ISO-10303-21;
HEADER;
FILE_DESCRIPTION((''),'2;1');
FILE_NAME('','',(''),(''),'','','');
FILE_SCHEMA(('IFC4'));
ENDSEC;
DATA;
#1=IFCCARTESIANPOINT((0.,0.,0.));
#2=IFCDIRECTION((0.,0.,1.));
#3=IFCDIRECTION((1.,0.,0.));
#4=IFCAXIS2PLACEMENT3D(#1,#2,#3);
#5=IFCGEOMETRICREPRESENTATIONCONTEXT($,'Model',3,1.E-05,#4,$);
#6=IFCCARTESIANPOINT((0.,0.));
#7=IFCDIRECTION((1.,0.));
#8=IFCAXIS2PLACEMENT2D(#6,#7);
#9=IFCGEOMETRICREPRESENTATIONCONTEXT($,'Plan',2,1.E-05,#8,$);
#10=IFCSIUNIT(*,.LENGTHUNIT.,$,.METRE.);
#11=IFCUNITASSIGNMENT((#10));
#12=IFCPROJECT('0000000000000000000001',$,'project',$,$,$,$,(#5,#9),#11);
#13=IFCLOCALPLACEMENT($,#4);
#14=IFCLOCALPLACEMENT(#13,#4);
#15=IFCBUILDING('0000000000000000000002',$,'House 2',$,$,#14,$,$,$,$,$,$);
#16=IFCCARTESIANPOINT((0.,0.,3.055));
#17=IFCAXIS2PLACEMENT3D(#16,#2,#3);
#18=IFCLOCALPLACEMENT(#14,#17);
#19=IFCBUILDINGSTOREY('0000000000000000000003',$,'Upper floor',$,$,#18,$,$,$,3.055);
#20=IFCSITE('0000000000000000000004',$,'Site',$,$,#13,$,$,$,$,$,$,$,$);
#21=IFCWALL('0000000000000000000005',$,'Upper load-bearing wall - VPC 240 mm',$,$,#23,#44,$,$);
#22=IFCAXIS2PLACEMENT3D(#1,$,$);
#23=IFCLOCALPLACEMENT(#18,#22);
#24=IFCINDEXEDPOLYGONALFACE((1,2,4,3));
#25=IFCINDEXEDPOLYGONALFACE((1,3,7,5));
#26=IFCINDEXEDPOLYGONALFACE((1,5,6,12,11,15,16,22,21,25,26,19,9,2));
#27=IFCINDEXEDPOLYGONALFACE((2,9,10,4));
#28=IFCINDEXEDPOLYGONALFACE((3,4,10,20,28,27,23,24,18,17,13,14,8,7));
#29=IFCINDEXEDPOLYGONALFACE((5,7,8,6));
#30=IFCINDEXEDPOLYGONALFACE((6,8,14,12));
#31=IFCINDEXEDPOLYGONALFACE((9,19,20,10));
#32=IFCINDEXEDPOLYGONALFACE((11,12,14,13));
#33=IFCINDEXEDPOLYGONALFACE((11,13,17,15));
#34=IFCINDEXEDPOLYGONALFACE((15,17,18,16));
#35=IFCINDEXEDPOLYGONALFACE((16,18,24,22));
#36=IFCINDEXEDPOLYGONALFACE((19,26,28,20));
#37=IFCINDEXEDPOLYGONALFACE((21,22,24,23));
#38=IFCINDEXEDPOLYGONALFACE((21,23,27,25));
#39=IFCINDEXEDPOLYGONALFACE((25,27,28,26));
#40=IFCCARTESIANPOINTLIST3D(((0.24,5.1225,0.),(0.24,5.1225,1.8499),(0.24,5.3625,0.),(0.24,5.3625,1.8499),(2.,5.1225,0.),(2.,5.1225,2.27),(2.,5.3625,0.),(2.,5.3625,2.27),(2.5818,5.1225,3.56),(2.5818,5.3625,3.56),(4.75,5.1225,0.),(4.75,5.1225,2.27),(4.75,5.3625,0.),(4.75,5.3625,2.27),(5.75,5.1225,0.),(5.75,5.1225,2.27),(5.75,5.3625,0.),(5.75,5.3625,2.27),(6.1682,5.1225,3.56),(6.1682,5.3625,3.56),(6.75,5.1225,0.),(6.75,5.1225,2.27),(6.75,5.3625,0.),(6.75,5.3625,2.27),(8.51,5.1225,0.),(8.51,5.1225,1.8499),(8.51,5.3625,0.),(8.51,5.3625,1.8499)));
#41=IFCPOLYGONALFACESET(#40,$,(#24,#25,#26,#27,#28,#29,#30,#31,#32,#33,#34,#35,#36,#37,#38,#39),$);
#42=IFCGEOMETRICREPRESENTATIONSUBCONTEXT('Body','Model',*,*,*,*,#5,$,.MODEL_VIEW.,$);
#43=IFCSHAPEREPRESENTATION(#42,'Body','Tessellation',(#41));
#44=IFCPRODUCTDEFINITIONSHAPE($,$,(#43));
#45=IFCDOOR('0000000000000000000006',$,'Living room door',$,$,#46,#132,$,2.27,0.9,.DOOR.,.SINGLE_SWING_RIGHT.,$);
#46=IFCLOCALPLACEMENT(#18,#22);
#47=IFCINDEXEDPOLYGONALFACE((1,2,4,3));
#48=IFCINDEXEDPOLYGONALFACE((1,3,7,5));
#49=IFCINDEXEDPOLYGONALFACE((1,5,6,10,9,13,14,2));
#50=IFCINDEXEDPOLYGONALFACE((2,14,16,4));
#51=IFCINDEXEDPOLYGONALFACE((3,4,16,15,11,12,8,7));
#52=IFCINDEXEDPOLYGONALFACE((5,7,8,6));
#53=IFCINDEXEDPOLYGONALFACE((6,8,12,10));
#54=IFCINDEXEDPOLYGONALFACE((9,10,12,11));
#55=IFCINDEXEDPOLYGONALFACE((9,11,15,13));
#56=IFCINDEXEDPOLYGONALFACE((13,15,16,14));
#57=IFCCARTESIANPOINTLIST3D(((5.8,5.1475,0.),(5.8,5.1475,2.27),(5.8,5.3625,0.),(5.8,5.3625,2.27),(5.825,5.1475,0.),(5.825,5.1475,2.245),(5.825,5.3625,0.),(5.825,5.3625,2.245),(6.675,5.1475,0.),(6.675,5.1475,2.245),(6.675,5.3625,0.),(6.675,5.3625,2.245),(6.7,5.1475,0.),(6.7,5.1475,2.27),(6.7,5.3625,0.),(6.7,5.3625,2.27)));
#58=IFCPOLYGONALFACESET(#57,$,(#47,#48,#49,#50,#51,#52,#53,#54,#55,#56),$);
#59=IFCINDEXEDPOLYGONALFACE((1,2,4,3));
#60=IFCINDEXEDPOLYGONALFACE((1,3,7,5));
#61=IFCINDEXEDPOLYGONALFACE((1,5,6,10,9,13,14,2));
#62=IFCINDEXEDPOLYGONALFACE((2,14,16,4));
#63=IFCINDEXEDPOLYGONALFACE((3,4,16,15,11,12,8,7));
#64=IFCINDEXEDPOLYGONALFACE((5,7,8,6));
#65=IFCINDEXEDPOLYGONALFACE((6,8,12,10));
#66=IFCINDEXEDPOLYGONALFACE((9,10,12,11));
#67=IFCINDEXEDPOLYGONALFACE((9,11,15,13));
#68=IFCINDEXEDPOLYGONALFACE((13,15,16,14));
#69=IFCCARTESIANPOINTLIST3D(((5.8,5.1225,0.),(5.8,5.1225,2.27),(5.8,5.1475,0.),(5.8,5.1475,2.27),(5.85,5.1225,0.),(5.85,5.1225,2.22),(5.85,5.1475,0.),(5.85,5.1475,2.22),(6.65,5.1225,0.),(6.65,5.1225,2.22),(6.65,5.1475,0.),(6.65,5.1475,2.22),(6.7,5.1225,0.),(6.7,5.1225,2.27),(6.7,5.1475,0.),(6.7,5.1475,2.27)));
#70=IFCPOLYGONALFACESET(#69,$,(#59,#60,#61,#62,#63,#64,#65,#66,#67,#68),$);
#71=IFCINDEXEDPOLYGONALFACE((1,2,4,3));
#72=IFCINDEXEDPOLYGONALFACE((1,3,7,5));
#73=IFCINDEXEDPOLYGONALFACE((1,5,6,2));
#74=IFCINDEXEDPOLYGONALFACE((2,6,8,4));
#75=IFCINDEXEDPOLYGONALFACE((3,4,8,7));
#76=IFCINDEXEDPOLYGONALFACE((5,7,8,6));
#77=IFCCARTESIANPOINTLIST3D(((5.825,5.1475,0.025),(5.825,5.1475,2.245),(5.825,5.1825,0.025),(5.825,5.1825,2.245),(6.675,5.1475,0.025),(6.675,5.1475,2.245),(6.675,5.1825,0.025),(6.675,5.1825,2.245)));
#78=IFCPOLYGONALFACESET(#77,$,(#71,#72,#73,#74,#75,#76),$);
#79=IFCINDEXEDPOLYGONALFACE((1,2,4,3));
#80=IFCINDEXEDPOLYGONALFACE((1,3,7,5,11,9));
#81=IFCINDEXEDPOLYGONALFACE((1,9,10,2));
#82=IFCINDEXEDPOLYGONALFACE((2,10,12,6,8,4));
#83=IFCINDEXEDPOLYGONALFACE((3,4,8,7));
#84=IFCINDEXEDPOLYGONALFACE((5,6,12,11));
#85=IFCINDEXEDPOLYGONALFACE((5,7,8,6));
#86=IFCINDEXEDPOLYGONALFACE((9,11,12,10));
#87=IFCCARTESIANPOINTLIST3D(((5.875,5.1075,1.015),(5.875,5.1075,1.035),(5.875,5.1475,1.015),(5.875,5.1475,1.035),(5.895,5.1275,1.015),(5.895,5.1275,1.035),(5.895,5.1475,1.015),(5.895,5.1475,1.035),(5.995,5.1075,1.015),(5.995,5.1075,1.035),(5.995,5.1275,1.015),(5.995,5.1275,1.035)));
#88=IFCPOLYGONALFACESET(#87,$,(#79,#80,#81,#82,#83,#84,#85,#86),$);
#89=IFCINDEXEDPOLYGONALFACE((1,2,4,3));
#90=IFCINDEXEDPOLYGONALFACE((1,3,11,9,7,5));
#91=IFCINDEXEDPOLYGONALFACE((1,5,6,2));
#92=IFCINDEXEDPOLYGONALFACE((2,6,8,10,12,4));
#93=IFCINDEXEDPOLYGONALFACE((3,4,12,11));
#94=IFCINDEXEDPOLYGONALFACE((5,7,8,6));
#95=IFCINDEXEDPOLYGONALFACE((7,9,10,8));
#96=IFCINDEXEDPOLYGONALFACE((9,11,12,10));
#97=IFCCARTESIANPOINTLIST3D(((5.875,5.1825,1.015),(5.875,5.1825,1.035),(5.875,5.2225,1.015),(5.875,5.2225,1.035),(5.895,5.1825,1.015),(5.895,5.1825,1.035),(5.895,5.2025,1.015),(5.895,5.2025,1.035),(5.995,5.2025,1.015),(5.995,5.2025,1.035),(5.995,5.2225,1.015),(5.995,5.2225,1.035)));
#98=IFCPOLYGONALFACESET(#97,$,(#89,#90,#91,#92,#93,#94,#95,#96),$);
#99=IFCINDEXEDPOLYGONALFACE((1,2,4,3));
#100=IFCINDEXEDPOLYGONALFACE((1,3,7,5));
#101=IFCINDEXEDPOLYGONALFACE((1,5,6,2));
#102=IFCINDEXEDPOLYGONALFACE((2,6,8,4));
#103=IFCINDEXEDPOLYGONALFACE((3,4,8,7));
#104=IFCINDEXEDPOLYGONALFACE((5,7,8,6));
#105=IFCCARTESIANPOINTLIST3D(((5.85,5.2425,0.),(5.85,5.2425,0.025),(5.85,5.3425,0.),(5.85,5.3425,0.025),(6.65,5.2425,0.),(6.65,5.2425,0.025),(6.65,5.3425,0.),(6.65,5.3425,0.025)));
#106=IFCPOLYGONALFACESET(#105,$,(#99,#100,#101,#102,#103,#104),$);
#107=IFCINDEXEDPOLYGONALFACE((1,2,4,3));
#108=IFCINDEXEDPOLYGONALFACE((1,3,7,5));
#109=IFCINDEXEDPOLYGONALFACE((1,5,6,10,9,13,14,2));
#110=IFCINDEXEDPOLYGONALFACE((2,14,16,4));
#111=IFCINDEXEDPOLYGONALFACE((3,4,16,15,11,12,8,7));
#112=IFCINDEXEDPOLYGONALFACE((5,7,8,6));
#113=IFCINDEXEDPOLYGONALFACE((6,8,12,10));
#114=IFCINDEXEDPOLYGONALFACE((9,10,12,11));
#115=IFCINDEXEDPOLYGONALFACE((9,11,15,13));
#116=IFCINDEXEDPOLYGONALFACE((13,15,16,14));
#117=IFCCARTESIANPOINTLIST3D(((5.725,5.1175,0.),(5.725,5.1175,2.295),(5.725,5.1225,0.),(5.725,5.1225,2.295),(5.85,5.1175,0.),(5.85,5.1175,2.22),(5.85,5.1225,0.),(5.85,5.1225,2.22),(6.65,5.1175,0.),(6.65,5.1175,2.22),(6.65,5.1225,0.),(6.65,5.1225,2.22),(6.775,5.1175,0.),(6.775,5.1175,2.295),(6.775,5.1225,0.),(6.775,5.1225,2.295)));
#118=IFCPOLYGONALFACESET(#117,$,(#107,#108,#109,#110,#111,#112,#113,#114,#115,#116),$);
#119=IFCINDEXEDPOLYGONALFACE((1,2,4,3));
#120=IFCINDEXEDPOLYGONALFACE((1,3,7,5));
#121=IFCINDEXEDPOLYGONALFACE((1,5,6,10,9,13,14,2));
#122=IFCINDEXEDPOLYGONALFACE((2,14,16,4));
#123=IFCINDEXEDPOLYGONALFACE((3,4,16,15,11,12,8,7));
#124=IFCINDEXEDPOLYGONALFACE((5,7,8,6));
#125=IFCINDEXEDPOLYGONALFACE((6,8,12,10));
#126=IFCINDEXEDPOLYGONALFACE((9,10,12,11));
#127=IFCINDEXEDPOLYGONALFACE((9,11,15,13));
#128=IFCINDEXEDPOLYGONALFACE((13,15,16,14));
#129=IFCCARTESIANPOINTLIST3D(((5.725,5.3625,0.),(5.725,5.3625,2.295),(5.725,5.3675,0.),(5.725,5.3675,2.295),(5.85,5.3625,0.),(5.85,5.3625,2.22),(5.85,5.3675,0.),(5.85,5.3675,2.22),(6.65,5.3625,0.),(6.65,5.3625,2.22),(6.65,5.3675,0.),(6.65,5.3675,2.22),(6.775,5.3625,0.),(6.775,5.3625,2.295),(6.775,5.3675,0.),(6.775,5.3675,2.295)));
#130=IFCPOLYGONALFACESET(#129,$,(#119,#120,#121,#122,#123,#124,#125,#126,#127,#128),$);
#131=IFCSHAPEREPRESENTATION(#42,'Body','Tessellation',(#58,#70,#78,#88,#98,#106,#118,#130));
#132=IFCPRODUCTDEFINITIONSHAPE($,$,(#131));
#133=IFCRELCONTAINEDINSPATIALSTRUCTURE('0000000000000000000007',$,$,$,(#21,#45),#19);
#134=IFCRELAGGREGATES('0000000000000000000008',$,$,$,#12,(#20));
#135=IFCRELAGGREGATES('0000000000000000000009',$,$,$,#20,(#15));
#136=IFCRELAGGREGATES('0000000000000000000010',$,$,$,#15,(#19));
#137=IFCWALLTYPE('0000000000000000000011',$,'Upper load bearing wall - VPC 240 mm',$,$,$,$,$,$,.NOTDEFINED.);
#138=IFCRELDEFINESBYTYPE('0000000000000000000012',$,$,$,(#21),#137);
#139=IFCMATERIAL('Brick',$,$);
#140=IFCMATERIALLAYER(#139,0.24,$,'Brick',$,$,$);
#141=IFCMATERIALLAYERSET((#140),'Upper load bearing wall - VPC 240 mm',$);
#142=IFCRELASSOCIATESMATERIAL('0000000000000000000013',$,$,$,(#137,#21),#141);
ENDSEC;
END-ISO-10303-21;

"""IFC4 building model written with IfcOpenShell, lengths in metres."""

from ifc_helpers import new_model, entity, si_unit, frame, origin_with_axes, origin_2d_with_axis, place, context, subcontext, project, spatial, line, indexed_curve, outline, extrude, clip, halfspace, shape, source, transform, mapped, material, layer, layer_set, layer_usage, type_object, element, fill, save


model = new_model("IFC4")

# Units and contexts
model_context = context("Model", 3, precision=1e-05, world=origin_with_axes())
plan_context = context("Plan", 2, precision=1e-05, world=origin_2d_with_axis())
body_context_1 = subcontext(model_context, "Body", "Model", "MODEL_VIEW")
body_context_2 = subcontext(plan_context, "Body", "Plan", "PLAN_VIEW")
ifc_project = project(units=[si_unit("LENGTHUNIT", "METRE")], contexts=[model_context, plan_context])

# Site, building, storey
site_placement = place(None, origin_with_axes())
site = spatial("IfcSite", under=ifc_project, at=site_placement, Name="Site")
building_placement = place(site_placement, origin_with_axes())
building = spatial("IfcBuilding", under=site, at=building_placement, Name="House 2")
storey_placement = place(building_placement, frame((0.0, 0.0, 3.055), z_axis=(0.0, 0.0, 1.0), x_axis=(1.0, 0.0, 0.0)))
storey = spatial("IfcBuildingStorey", under=building, at=storey_placement, Name="Upper floor", Elevation=3.055)

# Shared definitions
ifc_material_1 = material(Name="Brick")

# Wall, openings, door
ifc_layer_1 = layer(ifc_material_1, 0.24, Name="Brick")
ifc_layer_set_1 = layer_set([ifc_layer_1], Name="Upper load bearing wall - VPC 240 mm")
ifc_layer_usage_1 = layer_usage(ifc_layer_set_1, "AXIS2", "NEGATIVE", 0.12)
wall_type_1 = type_object("IfcWallType", Name="Upper load bearing wall - VPC 240 mm", PredefinedType="NOTDEFINED", material=ifc_layer_set_1)
wall_1_placement = place(storey_placement, frame((0.24, 5.2425, 0.0), z_axis=(0.0, 0.0, 1.0), x_axis=(1.0, 0.0, 0.0)))
wall_1 = element("IfcWall", 1, at=wall_1_placement, inside=storey, type_object=wall_type_1, material=ifc_layer_usage_1, Name="Upper load-bearing wall - VPC 240 mm", context=body_context_1, shape_type="Clipping", body=[
    clip(clip(clip(extrude(outline(indexed_curve([(0.0, 0.0), (0.0, 0.24), (8.27, 0.24), (8.27, 0.0), (0.0, 0.0)], self_intersect=False)), frame((0.0, -0.12, 0.0), z_axis=(0.0, 0.0, 1.0), x_axis=(1.0, 0.0, 0.0)), (0.0, 0.0, 1.0), 3.56), halfspace(frame((-0.259, -5.2425, 1.6608), z_axis=(-0.58975, 0.0, 0.807586), x_axis=(0.0, 1.0, 0.0)), False)), halfspace(frame((8.529, -5.2425, 1.6608), z_axis=(0.58975, 0.0, 0.807586), x_axis=(0.0, -1.0, 0.0)), False)), halfspace(frame((-0.24, -5.2425, 3.56), z_axis=(0.0, 0.0, 1.0), x_axis=(-1.0, 0.0, 0.0)), False)),
])
opening_1_placement = place(wall_1_placement, frame((5.51, 0.0, 0.0), z_axis=(0.0, 0.0, 1.0), x_axis=(1.0, 0.0, 0.0)))
opening_1 = element("IfcOpeningElement", 2, at=opening_1_placement, cuts=wall_1, PredefinedType="OPENING", context=body_context_1, shape_type="SweptSolid", body=[
    extrude(outline(indexed_curve([(0.0, 0.0), (0.0, 0.34), (1.0, 0.34), (1.0, 0.0), (0.0, 0.0)], self_intersect=False)), frame((0.0, -0.17, 0.0), z_axis=(0.0, 0.0, 1.0), x_axis=(1.0, 0.0, 0.0)), (0.0, 0.0, 1.0), 2.27),
])
opening_2_placement = place(wall_1_placement, frame((1.76, 0.0, 0.0), z_axis=(0.0, 0.0, 1.0), x_axis=(1.0, 0.0, 0.0)))
element("IfcOpeningElement", 3, at=opening_2_placement, cuts=wall_1, PredefinedType="OPENING", context=body_context_1, shape_type="SweptSolid", body=[
    extrude(outline(indexed_curve([(0.0, 0.0), (0.0, 0.34), (2.75, 0.34), (2.75, 0.0), (0.0, 0.0)], self_intersect=False)), frame((0.0, -0.17, 0.0), z_axis=(0.0, 0.0, 1.0), x_axis=(1.0, 0.0, 0.0)), (0.0, 0.0, 1.0), 2.27),
])
shared_indexed_poly_curve = entity("IfcIndexedPolyCurve", entity("IfcCartesianPointList2D", [[-0.075, 0.0], [-0.075, 2.295], [0.975, 2.295], [0.975, 0.0], [0.85, 0.0], [0.85, 2.22], [0.05, 2.22], [0.05, 0.0]]), [entity("IfcLineIndex", [1, 2, 3, 4, 5, 6, 7, 8, 1])])
shared_shape_1 = source(origin_with_axes(), body_context_2, "Body", "Curve2D", [
    entity("IfcIndexedPolyCurve", entity("IfcCartesianPointList2D", [[0.0, -0.12], [0.0, 0.12], [0.025, 0.12], [0.025, -0.095], [0.05, -0.095], [0.05, -0.12]]), [entity("IfcLineIndex", [1, 2, 3, 4, 5, 6, 1])]),
    entity("IfcIndexedPolyCurve", entity("IfcCartesianPointList2D", [[0.9, -0.12], [0.9, 0.12], [0.875, 0.12], [0.875, -0.095], [0.85, -0.095], [0.85, -0.12]]), [entity("IfcLineIndex", [1, 2, 3, 4, 5, 6, 1])]),
    entity("IfcTrimmedCurve", entity("IfcEllipse", entity("IfcAxis2Placement2D", entity("IfcCartesianPoint", [0.84, 0.12]), entity("IfcDirection", [1.0, 0.0])), 0.815, 0.85), [entity("IfcCartesianPoint", [0.84, 0.97])], [entity("IfcCartesianPoint", [0.025, 0.12])], True, "CARTESIAN"),
    entity("IfcIndexedPolyCurve", entity("IfcCartesianPointList2D", [[0.875, 0.12], [0.84, 0.12], [0.84, 0.97], [0.875, 0.97]]), [entity("IfcLineIndex", [1, 2, 3, 4, 1])]),
])
door_placement = place(opening_1_placement, frame((0.05, 0.0, 0.0), z_axis=(0.0, 0.0, 1.0), x_axis=(1.0, 0.0, 0.0)))
door = element("IfcDoor", 4, at=door_placement, inside=storey, Name="Living room door", OperationType="SINGLE_SWING_RIGHT", OverallHeight=2.27, OverallWidth=0.9, PredefinedType="DOOR", shapes=[
    shape(body_context_1, "Body", "SweptSolid", [extrude(outline(indexed_curve([(0.0, 0.0), (0.0, 2.27), (0.9, 2.27), (0.9, 0.0), (0.875, 0.0), (0.875, 2.245), (0.025, 2.245), (0.025, 0.0)], segments=[line(1, 2, 3, 4, 5, 6, 7, 8, 1)])), frame((0.0, -0.095, 0.0), z_axis=(0.0, -1.0, 0.0), x_axis=(1.0, 0.0, 0.0)), (0.0, 0.0, -1.0), 0.215), extrude(outline(indexed_curve([(0.0, 0.0), (0.0, 2.27), (0.9, 2.27), (0.9, 0.0), (0.85, 0.0), (0.85, 2.22), (0.05, 2.22), (0.05, 0.0)], segments=[line(1, 2, 3, 4, 5, 6, 7, 8, 1)])), frame((0.0, -0.12, 0.0), z_axis=(0.0, -1.0, 0.0), x_axis=(1.0, 0.0, 0.0)), (0.0, 0.0, -1.0), 0.025), extrude(outline(indexed_curve([(0.0, 0.0), (0.85, 0.0), (0.85, 0.035), (0.0, 0.035)], segments=[line(1, 2, 3, 4, 1)])), frame((0.025, -0.095, 0.025), z_axis=(0.0, 0.0, 1.0), x_axis=(1.0, 0.0, 0.0)), (0.0, 0.0, 1.0), 2.22), extrude(outline(indexed_curve([(0.0, 0.0), (0.0, -0.04), (0.12, -0.04), (0.12, -0.02), (0.02, -0.02), (0.02, 0.0)], segments=[line(1, 2, 3, 4, 5, 6, 1)])), frame((0.075, -0.095, 1.015), z_axis=(0.0, 0.0, 1.0), x_axis=(1.0, 0.0, 0.0)), (0.0, 0.0, 1.0), 0.02), extrude(outline(indexed_curve([(0.0, 0.0), (0.0, 0.04), (0.12, 0.04), (0.12, 0.02), (0.02, 0.02), (0.02, 0.0)], segments=[line(1, 2, 3, 4, 5, 6, 1)])), frame((0.075, -0.06, 1.015), z_axis=(0.0, 0.0, 1.0), x_axis=(1.0, 0.0, 0.0)), (0.0, 0.0, 1.0), 0.02), extrude(outline(indexed_curve([(0.0, 0.0), (0.8, 0.0), (0.8, 0.1), (0.0, 0.1)], segments=[line(1, 2, 3, 4, 1)])), frame((0.05, 0.0, 0.0), z_axis=(0.0, 0.0, 1.0), x_axis=(1.0, 0.0, 0.0)), (0.0, 0.0, 1.0), 0.025), entity("IfcExtrudedAreaSolid", entity("IfcArbitraryClosedProfileDef", "AREA", None, shared_indexed_poly_curve), entity("IfcAxis2Placement3D", entity("IfcCartesianPoint", [0.0, -0.125, 0.0]), entity("IfcDirection", [0.0, -1.0, 0.0]), entity("IfcDirection", [1.0, 0.0, 0.0])), entity("IfcDirection", [0.0, 0.0, -1.0]), 0.005), entity("IfcExtrudedAreaSolid", entity("IfcArbitraryClosedProfileDef", "AREA", None, shared_indexed_poly_curve), entity("IfcAxis2Placement3D", entity("IfcCartesianPoint", [0.0, 0.12, 0.0]), entity("IfcDirection", [0.0, -1.0, 0.0]), entity("IfcDirection", [1.0, 0.0, 0.0])), entity("IfcDirection", [0.0, 0.0, -1.0]), 0.005)]),
    shape(body_context_2, "Body", "MappedRepresentation", [mapped(shared_shape_1, transform((0.0, 0.0, 1.135), x_axis=(1.0, 0.0, 0.0), y_axis=(0.0, 1.0, 0.0), z_axis=(0.0, 0.0, 1.0), scale=1.0))]),
])
fill(opening_1, door)

save(model, "model.ifc")
